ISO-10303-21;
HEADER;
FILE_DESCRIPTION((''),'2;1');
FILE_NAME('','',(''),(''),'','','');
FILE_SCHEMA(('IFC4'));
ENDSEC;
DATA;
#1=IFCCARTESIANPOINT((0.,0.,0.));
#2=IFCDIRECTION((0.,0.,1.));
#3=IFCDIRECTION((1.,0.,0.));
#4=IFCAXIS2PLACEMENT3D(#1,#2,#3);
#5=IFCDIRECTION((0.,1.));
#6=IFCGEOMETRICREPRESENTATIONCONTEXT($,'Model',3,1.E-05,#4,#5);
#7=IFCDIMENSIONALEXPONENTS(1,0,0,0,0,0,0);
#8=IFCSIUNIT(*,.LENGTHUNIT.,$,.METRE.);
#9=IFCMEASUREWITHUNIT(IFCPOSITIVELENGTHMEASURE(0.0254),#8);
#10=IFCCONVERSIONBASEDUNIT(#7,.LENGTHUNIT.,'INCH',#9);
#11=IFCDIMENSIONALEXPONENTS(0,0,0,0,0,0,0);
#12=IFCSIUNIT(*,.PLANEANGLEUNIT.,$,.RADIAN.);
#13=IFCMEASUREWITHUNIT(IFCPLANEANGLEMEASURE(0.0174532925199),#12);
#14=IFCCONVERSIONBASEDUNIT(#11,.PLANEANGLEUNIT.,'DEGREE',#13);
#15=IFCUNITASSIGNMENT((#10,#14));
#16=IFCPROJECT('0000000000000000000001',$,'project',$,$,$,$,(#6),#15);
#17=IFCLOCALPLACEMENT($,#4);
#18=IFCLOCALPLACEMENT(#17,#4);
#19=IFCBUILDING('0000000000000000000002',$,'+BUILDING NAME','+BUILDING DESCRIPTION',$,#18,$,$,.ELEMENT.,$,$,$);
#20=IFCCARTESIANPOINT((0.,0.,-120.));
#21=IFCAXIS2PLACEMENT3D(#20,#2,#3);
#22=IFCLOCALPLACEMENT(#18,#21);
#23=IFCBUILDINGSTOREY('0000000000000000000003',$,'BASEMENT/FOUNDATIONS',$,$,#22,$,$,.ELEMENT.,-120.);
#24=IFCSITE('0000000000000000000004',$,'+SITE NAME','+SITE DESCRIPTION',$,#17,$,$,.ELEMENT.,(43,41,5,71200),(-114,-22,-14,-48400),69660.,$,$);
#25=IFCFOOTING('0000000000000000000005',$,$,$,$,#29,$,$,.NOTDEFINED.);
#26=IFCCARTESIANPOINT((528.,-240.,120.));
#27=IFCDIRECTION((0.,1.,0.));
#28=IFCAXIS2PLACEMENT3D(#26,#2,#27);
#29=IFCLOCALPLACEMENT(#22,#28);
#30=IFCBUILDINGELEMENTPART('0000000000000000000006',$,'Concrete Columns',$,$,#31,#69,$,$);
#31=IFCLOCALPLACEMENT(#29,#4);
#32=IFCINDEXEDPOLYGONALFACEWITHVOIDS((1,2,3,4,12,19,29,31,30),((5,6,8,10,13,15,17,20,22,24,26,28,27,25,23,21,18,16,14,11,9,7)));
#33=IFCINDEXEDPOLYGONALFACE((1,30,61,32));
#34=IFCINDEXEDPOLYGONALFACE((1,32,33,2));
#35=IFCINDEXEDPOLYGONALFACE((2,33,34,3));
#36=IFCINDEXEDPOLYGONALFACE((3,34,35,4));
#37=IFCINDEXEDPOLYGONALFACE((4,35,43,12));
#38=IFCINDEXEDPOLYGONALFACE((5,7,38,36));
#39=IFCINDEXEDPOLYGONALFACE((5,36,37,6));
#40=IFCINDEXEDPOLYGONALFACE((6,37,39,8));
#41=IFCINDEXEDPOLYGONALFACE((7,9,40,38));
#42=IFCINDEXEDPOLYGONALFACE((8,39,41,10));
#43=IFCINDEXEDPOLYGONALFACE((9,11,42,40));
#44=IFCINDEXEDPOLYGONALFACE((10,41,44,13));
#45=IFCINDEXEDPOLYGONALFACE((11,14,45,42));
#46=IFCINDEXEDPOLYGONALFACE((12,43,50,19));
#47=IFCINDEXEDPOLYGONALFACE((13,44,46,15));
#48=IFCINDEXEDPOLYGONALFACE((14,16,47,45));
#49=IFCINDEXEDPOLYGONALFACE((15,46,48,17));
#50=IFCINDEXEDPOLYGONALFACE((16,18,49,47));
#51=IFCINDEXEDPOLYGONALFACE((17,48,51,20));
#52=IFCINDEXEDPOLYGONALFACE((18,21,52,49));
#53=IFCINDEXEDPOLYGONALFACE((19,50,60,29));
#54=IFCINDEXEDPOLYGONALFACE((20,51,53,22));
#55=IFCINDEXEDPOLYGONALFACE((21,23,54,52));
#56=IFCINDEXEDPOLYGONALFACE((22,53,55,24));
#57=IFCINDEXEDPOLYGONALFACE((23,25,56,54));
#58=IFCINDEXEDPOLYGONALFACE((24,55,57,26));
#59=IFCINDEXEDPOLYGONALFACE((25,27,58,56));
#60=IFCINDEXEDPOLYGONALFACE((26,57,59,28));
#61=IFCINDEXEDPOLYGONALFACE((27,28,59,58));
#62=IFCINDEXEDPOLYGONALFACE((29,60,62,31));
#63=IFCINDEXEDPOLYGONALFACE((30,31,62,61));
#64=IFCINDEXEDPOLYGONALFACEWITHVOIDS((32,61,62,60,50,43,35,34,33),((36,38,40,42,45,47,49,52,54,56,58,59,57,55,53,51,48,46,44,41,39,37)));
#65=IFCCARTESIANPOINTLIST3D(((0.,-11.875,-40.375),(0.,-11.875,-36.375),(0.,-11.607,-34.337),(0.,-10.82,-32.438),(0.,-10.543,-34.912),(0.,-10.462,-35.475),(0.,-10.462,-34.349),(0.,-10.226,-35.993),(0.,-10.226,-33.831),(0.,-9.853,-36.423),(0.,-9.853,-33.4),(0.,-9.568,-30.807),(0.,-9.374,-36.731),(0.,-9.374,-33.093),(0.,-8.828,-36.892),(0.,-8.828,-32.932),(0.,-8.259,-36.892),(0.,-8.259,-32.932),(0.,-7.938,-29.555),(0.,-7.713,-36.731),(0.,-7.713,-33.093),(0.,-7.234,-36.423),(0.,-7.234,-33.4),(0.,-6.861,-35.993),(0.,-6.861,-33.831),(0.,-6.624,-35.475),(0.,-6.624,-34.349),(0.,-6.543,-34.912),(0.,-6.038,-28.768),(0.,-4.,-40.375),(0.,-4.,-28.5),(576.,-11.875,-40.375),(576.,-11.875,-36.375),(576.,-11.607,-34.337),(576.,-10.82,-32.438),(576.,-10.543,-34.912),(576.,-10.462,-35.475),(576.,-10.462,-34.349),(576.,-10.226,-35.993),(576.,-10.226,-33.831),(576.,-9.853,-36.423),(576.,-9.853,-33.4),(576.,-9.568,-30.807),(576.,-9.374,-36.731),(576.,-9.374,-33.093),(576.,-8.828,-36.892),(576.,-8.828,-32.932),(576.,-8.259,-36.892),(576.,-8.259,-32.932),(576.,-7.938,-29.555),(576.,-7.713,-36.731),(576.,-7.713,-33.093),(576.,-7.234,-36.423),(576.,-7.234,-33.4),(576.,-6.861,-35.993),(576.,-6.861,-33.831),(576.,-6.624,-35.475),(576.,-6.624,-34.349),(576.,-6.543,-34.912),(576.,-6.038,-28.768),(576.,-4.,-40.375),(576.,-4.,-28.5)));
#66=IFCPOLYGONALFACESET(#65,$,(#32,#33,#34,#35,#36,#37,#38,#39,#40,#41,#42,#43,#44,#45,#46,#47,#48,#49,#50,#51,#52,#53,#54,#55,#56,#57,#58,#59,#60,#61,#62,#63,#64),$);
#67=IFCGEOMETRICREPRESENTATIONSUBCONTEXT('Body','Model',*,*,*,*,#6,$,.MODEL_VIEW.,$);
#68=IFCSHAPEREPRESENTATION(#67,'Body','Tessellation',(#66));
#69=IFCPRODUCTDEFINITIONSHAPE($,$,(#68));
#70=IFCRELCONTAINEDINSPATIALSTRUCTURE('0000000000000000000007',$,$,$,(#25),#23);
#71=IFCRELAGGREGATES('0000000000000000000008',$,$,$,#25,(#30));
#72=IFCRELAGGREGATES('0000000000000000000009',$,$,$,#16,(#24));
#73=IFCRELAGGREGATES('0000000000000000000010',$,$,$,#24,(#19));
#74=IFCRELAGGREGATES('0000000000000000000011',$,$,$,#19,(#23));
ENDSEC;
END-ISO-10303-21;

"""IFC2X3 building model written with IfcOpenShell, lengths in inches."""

from ifc_helpers import new_model, entity, si_unit, converted_unit, point, direction, frame, frame_2d, origin_with_axes, place, context, subcontext, project, spatial, polyline, circle_curve, parameter, trimmed, segment, composite_curve, outline, extrude, element, aggregate, save


model = new_model("IFC2X3")

# Units and contexts
model_context = context("Model", 3, precision=1e-05, world=origin_with_axes(), true_north=direction((0.0, 1.0)))
body_context = subcontext(model_context, "Body", "Model", "MODEL_VIEW")
ifc_project = project(units=[converted_unit("LENGTHUNIT", "INCH", entity("IfcPositiveLengthMeasure", 0.0254), si_unit("LENGTHUNIT", "METRE"), dimensions=[1, 0, 0, 0, 0, 0, 0]), converted_unit("PLANEANGLEUNIT", "DEGREE", entity("IfcPlaneAngleMeasure", 0.0174532925199), si_unit("PLANEANGLEUNIT", "RADIAN"), dimensions=[0, 0, 0, 0, 0, 0, 0])], contexts=[model_context])

# Site, building, storey
site_placement = place(None, origin_with_axes())
site = spatial("IfcSite", under=ifc_project, at=site_placement, Name="+SITE NAME", Description="+SITE DESCRIPTION", CompositionType="ELEMENT", RefLatitude=(43, 41, 5, 71200), RefLongitude=(-114, -22, -14, -48400), RefElevation=69660.0)
building_placement = place(site_placement, origin_with_axes())
building = spatial("IfcBuilding", under=site, at=building_placement, Name="+BUILDING NAME", Description="+BUILDING DESCRIPTION", CompositionType="ELEMENT")
storey_placement = place(building_placement, frame((0.0, 0.0, -120.0), z_axis=(0.0, 0.0, 1.0), x_axis=(1.0, 0.0, 0.0)))
storey = spatial("IfcBuildingStorey", under=building, at=storey_placement, Name="BASEMENT/FOUNDATIONS", CompositionType="ELEMENT", Elevation=-120.0)

# Footing, building element part
footing_1_placement = place(storey_placement, frame((528.0, -240.0, 120.0), z_axis=(0.0, 0.0, 1.0), x_axis=(0.0, 1.0, 0.0)))
footing_1 = element("IfcFooting", 1, at=footing_1_placement, inside=storey, PredefinedType="NOTDEFINED")
building_element_part_1_placement = place(footing_1_placement, origin_with_axes())
building_element_part_1 = element("IfcBuildingElementPart", 2, at=building_element_part_1_placement, Name="Concrete Columns", context=body_context, shape_type="SweptSolid", body=[
    extrude(outline(composite_curve([segment(trimmed(circle_curve(frame_2d((4.0, -36.375), x_axis=(1.0, 0.0)), 7.875), [point((11.875, -36.375)), parameter(0.0)], [point((4.0, -28.5)), parameter(90.0)], True, "CARTESIAN"), True, "CONTINUOUS"), segment(polyline([(4.0, -28.5), (4.0, -40.375), (11.875, -40.375), (11.875, -36.375)]), True, "CONTINUOUS")], self_intersect=False), holes=[composite_curve([segment(trimmed(circle_curve(frame_2d((8.543, -34.912), x_axis=(-1.0, 0.0)), 2.0), [point((10.543, -34.912)), parameter(180.0)], [point((6.543, -34.912)), parameter(0.0)], False, "CARTESIAN"), True, "CONTINUOUS"), segment(trimmed(circle_curve(frame_2d((8.543, -34.912), x_axis=(1.0, 0.0)), 2.0), [point((6.543, -34.912)), parameter(180.0)], [point((10.543, -34.912)), parameter(0.0)], False, "CARTESIAN"), True, "CONTINUOUS")], self_intersect=False)]), frame((0.0, 0.0, 0.0), z_axis=(-1.0, 0.0, 0.0), x_axis=(0.0, -1.0, 0.0)), (0.0, 0.0, -1.0), 576.0),
])
aggregate(footing_1, [building_element_part_1])

save(model, "model.ifc")
